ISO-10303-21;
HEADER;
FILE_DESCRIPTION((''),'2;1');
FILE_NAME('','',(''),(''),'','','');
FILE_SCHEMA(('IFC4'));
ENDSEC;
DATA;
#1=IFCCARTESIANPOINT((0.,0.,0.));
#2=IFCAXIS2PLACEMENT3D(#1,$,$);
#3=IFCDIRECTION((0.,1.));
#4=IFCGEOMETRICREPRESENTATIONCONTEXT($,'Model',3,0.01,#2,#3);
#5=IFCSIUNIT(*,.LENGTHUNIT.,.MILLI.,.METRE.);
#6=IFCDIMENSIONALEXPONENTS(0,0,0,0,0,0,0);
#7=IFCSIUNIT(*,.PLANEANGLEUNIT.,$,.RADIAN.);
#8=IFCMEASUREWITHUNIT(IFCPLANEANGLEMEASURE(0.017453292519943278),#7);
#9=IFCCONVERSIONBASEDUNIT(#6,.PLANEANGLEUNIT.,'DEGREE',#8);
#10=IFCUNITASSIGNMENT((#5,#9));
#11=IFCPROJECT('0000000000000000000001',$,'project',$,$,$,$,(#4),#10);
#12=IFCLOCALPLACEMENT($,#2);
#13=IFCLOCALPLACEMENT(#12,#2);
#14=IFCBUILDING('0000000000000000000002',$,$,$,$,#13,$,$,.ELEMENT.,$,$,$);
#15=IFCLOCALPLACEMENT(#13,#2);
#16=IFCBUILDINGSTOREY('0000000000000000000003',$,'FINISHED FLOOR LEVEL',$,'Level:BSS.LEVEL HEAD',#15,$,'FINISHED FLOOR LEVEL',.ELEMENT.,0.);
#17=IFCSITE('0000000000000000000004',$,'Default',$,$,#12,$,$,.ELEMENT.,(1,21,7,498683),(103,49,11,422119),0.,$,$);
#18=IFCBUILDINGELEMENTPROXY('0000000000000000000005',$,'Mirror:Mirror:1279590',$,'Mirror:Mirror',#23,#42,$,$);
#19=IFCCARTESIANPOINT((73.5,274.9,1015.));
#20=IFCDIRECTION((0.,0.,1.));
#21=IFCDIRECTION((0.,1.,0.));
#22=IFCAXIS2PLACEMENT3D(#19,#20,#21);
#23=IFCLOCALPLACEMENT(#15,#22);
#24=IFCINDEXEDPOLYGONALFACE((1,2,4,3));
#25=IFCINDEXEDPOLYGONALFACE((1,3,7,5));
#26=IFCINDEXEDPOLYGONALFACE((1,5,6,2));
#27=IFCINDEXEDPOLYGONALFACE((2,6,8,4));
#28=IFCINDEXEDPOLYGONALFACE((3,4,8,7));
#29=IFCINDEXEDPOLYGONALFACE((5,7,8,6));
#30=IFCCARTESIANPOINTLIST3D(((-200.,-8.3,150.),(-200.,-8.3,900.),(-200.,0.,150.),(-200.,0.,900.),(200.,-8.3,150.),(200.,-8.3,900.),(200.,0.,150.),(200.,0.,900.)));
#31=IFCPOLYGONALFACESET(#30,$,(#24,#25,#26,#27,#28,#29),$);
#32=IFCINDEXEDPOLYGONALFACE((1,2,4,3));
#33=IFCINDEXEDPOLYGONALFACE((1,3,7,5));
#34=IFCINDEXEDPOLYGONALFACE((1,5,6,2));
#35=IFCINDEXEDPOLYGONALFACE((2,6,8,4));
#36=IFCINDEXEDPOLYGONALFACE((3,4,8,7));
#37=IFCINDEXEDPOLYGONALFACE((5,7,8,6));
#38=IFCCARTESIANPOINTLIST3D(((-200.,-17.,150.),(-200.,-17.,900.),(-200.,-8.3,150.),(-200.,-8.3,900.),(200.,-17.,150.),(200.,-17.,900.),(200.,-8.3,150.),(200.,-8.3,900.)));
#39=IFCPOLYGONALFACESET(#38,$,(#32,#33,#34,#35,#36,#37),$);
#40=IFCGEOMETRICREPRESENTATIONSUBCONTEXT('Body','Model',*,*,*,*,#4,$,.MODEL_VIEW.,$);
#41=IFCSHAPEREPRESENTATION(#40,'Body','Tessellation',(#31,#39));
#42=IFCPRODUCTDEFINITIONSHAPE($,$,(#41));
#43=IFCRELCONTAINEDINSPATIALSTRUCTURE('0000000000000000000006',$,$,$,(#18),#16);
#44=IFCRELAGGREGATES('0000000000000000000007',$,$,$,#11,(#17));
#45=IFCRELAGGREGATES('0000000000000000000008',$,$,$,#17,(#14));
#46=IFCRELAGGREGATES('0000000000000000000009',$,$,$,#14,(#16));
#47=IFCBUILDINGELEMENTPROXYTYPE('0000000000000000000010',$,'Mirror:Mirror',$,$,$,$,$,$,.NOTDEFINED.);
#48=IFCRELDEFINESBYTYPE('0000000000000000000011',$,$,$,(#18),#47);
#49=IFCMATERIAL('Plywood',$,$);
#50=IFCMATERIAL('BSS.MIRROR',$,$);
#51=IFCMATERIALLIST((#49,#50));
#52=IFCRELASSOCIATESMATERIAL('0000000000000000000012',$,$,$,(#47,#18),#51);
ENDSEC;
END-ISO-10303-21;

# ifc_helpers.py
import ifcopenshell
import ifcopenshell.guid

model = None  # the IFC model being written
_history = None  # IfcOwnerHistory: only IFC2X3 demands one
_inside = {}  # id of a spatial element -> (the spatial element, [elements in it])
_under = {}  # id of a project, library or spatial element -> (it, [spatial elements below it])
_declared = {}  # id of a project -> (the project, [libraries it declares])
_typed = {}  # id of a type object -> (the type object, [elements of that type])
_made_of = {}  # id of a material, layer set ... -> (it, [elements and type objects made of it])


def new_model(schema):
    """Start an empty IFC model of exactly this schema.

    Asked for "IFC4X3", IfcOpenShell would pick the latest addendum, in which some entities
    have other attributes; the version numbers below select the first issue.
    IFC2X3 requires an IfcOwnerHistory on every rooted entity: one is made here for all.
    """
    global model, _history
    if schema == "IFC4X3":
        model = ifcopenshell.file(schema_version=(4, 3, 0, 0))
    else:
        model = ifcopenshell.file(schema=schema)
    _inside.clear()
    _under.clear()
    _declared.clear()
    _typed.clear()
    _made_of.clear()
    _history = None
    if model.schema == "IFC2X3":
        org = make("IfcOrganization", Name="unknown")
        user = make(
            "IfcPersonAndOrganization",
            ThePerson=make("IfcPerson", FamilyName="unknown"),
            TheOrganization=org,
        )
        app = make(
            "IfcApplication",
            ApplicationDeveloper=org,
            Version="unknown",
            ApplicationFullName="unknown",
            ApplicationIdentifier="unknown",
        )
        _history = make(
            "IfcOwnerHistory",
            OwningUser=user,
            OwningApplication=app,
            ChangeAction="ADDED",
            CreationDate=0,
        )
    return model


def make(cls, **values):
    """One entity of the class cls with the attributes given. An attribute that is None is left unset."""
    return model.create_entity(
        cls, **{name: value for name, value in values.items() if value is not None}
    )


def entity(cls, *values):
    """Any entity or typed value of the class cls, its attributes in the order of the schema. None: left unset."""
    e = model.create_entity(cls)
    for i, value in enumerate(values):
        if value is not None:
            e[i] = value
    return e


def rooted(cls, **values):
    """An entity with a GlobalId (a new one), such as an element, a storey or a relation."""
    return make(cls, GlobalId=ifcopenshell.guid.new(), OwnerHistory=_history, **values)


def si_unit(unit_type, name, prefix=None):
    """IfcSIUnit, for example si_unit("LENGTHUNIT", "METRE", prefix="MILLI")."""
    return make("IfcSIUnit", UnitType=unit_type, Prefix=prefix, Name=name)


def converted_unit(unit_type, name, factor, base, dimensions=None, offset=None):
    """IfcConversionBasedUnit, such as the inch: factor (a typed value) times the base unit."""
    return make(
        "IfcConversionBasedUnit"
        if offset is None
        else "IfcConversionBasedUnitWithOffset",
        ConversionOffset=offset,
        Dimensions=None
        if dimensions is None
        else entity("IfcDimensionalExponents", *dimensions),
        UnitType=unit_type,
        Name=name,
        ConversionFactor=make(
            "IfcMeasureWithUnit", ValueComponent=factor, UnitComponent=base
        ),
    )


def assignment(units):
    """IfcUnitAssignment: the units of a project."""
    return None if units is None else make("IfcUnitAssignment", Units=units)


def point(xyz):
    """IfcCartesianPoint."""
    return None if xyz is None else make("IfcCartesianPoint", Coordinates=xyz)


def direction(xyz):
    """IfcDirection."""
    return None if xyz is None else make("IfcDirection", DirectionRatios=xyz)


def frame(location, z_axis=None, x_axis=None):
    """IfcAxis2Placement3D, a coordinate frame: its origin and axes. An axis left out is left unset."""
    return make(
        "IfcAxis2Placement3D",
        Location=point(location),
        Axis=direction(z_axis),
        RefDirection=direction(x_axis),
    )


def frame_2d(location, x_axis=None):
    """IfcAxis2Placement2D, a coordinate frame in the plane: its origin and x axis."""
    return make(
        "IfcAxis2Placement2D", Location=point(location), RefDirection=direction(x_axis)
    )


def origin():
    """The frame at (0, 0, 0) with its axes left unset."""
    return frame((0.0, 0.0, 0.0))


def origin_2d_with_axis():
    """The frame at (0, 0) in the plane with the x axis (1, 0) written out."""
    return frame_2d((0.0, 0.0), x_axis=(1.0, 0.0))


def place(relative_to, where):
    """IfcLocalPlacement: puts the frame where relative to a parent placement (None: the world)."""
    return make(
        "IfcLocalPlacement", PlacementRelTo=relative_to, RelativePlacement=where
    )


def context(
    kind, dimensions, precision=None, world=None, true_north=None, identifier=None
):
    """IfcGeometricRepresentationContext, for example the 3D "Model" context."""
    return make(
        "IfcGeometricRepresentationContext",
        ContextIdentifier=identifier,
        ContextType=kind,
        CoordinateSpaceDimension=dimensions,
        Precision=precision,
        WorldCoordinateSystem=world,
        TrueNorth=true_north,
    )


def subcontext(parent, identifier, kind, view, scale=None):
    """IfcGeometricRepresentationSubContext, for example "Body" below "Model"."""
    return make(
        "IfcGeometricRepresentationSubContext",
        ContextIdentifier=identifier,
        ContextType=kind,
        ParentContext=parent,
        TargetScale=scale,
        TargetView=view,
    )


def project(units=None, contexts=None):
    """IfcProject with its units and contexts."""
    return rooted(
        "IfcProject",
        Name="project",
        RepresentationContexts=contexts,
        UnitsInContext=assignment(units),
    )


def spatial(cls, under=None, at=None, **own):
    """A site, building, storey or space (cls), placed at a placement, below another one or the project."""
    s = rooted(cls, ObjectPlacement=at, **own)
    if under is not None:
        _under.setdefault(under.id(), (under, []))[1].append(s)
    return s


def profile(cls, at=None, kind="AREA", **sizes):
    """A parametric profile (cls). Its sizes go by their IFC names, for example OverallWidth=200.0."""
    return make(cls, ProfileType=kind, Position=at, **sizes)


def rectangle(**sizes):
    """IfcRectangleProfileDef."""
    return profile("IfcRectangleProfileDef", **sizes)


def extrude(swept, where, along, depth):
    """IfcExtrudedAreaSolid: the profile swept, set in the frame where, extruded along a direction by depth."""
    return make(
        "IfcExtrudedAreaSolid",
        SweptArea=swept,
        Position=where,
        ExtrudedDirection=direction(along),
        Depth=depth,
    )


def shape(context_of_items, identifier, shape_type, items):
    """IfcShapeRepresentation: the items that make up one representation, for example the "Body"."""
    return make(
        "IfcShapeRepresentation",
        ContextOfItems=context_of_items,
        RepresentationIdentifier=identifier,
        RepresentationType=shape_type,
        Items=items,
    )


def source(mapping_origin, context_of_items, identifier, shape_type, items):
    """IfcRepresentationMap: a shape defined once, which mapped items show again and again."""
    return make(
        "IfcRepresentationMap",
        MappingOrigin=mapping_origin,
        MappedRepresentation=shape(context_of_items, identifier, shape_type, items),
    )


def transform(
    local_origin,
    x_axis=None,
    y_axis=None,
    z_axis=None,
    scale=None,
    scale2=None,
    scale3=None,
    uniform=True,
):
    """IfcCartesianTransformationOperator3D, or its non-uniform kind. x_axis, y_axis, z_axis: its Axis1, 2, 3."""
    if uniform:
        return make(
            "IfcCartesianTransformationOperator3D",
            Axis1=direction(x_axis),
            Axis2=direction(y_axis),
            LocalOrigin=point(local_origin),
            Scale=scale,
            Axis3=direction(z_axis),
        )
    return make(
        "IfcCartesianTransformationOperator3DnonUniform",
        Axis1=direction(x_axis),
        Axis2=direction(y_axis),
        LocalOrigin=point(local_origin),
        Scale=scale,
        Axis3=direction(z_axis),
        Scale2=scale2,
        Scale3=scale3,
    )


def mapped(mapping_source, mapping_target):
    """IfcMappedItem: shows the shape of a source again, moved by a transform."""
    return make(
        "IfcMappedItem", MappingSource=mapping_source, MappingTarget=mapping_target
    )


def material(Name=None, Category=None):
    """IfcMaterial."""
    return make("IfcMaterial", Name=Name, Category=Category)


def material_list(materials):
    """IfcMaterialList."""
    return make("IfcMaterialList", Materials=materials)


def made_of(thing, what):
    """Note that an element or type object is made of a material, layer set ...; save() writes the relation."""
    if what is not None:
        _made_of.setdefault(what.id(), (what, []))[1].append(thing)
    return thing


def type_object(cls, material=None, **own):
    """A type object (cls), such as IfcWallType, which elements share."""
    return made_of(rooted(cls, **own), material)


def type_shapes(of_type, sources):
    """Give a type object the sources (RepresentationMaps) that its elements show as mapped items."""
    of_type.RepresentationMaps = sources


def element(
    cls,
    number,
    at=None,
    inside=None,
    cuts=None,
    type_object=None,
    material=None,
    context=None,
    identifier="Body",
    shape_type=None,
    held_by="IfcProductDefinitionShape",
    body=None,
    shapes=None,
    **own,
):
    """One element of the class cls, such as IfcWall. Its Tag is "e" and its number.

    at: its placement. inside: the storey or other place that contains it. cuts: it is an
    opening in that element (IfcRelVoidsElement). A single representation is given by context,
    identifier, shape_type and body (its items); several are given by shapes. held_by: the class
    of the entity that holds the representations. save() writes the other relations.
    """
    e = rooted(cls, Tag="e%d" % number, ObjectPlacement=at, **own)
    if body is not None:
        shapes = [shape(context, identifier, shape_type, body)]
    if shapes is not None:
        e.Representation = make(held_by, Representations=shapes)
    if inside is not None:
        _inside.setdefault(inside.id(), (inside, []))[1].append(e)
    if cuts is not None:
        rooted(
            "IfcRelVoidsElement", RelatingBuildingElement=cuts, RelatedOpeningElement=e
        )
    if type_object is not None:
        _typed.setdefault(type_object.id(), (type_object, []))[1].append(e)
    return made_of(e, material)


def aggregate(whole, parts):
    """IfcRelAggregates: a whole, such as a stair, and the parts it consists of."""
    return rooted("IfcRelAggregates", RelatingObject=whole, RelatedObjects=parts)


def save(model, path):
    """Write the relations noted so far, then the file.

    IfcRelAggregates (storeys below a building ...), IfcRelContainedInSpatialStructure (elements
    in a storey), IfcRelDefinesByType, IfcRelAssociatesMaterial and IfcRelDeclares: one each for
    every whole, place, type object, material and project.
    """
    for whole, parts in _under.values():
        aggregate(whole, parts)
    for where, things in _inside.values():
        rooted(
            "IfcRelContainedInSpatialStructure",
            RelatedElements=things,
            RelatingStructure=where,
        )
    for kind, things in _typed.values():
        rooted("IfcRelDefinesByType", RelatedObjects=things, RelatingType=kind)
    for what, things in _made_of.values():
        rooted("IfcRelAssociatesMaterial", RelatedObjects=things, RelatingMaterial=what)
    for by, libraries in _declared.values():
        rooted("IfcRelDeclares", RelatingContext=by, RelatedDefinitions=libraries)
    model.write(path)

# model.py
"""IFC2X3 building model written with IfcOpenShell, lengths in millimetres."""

from ifc_helpers import new_model, entity, si_unit, converted_unit, direction, frame, origin, origin_2d_with_axis, place, context, subcontext, project, spatial, rectangle, extrude, source, transform, mapped, material, material_list, type_object, type_shapes, element, save


model = new_model("IFC2X3")

# Units and contexts
model_context = context("Model", 3, precision=0.01, world=origin(), true_north=direction((0.0, 1.0)))
body_context = subcontext(model_context, "Body", "Model", "MODEL_VIEW")
ifc_project = project(units=[si_unit("LENGTHUNIT", "METRE", prefix="MILLI"), converted_unit("PLANEANGLEUNIT", "DEGREE", entity("IfcPlaneAngleMeasure", 0.017453292519943278), si_unit("PLANEANGLEUNIT", "RADIAN"), dimensions=[0, 0, 0, 0, 0, 0, 0])], contexts=[model_context])

# Site, building, storey
site_placement = place(None, origin())
site = spatial("IfcSite", under=ifc_project, at=site_placement, Name="Default", CompositionType="ELEMENT", RefLatitude=(1, 21, 7, 498683), RefLongitude=(103, 49, 11, 422119), RefElevation=0.0)
building_placement = place(site_placement, origin())
building = spatial("IfcBuilding", under=site, at=building_placement, CompositionType="ELEMENT")
storey_placement = place(building_placement, origin())
storey = spatial("IfcBuildingStorey", under=building, at=storey_placement, Name="FINISHED FLOOR LEVEL", ObjectType="Level:BSS.LEVEL HEAD", LongName="FINISHED FLOOR LEVEL", CompositionType="ELEMENT", Elevation=0.0)

# Building element proxy
ifc_material_1 = material(Name="Plywood")
ifc_material_2 = material(Name="BSS.MIRROR")
ifc_material_list = material_list([ifc_material_1, ifc_material_2])
building_element_proxy_type = type_object("IfcBuildingElementProxyType", Name="Mirror:Mirror", PredefinedType="NOTDEFINED", material=ifc_material_list)
shared_shape = source(origin(), body_context, "Body", "SweptSolid", [
    extrude(rectangle(XDim=8.3, YDim=400.0, at=origin_2d_with_axis()), frame((0.0, -4.1, 150.0), z_axis=(0.0, 0.0, 1.0), x_axis=(0.0, 1.0, 0.0)), (0.0, 0.0, 1.0), 750.0),
    extrude(rectangle(XDim=8.7, YDim=400.0, at=origin_2d_with_axis()), frame((0.0, -12.6, 150.0), z_axis=(0.0, 0.0, 1.0), x_axis=(0.0, 1.0, 0.0)), (0.0, 0.0, 1.0), 750.0),
])
type_shapes(building_element_proxy_type, [shared_shape])
proxy_placement = place(storey_placement, frame((73.5, 274.9, 1015.0), z_axis=(0.0, 0.0, 1.0), x_axis=(0.0, 1.0, 0.0)))
element("IfcBuildingElementProxy", 1, at=proxy_placement, inside=storey, type_object=building_element_proxy_type, material=ifc_material_list, Name="Mirror:Mirror:1279590", ObjectType="Mirror:Mirror", context=body_context, shape_type="MappedRepresentation", body=[
    mapped(shared_shape, transform((0.0, 0.0, 0.0), scale=1.0)),
])

save(model, "model.ifc")
